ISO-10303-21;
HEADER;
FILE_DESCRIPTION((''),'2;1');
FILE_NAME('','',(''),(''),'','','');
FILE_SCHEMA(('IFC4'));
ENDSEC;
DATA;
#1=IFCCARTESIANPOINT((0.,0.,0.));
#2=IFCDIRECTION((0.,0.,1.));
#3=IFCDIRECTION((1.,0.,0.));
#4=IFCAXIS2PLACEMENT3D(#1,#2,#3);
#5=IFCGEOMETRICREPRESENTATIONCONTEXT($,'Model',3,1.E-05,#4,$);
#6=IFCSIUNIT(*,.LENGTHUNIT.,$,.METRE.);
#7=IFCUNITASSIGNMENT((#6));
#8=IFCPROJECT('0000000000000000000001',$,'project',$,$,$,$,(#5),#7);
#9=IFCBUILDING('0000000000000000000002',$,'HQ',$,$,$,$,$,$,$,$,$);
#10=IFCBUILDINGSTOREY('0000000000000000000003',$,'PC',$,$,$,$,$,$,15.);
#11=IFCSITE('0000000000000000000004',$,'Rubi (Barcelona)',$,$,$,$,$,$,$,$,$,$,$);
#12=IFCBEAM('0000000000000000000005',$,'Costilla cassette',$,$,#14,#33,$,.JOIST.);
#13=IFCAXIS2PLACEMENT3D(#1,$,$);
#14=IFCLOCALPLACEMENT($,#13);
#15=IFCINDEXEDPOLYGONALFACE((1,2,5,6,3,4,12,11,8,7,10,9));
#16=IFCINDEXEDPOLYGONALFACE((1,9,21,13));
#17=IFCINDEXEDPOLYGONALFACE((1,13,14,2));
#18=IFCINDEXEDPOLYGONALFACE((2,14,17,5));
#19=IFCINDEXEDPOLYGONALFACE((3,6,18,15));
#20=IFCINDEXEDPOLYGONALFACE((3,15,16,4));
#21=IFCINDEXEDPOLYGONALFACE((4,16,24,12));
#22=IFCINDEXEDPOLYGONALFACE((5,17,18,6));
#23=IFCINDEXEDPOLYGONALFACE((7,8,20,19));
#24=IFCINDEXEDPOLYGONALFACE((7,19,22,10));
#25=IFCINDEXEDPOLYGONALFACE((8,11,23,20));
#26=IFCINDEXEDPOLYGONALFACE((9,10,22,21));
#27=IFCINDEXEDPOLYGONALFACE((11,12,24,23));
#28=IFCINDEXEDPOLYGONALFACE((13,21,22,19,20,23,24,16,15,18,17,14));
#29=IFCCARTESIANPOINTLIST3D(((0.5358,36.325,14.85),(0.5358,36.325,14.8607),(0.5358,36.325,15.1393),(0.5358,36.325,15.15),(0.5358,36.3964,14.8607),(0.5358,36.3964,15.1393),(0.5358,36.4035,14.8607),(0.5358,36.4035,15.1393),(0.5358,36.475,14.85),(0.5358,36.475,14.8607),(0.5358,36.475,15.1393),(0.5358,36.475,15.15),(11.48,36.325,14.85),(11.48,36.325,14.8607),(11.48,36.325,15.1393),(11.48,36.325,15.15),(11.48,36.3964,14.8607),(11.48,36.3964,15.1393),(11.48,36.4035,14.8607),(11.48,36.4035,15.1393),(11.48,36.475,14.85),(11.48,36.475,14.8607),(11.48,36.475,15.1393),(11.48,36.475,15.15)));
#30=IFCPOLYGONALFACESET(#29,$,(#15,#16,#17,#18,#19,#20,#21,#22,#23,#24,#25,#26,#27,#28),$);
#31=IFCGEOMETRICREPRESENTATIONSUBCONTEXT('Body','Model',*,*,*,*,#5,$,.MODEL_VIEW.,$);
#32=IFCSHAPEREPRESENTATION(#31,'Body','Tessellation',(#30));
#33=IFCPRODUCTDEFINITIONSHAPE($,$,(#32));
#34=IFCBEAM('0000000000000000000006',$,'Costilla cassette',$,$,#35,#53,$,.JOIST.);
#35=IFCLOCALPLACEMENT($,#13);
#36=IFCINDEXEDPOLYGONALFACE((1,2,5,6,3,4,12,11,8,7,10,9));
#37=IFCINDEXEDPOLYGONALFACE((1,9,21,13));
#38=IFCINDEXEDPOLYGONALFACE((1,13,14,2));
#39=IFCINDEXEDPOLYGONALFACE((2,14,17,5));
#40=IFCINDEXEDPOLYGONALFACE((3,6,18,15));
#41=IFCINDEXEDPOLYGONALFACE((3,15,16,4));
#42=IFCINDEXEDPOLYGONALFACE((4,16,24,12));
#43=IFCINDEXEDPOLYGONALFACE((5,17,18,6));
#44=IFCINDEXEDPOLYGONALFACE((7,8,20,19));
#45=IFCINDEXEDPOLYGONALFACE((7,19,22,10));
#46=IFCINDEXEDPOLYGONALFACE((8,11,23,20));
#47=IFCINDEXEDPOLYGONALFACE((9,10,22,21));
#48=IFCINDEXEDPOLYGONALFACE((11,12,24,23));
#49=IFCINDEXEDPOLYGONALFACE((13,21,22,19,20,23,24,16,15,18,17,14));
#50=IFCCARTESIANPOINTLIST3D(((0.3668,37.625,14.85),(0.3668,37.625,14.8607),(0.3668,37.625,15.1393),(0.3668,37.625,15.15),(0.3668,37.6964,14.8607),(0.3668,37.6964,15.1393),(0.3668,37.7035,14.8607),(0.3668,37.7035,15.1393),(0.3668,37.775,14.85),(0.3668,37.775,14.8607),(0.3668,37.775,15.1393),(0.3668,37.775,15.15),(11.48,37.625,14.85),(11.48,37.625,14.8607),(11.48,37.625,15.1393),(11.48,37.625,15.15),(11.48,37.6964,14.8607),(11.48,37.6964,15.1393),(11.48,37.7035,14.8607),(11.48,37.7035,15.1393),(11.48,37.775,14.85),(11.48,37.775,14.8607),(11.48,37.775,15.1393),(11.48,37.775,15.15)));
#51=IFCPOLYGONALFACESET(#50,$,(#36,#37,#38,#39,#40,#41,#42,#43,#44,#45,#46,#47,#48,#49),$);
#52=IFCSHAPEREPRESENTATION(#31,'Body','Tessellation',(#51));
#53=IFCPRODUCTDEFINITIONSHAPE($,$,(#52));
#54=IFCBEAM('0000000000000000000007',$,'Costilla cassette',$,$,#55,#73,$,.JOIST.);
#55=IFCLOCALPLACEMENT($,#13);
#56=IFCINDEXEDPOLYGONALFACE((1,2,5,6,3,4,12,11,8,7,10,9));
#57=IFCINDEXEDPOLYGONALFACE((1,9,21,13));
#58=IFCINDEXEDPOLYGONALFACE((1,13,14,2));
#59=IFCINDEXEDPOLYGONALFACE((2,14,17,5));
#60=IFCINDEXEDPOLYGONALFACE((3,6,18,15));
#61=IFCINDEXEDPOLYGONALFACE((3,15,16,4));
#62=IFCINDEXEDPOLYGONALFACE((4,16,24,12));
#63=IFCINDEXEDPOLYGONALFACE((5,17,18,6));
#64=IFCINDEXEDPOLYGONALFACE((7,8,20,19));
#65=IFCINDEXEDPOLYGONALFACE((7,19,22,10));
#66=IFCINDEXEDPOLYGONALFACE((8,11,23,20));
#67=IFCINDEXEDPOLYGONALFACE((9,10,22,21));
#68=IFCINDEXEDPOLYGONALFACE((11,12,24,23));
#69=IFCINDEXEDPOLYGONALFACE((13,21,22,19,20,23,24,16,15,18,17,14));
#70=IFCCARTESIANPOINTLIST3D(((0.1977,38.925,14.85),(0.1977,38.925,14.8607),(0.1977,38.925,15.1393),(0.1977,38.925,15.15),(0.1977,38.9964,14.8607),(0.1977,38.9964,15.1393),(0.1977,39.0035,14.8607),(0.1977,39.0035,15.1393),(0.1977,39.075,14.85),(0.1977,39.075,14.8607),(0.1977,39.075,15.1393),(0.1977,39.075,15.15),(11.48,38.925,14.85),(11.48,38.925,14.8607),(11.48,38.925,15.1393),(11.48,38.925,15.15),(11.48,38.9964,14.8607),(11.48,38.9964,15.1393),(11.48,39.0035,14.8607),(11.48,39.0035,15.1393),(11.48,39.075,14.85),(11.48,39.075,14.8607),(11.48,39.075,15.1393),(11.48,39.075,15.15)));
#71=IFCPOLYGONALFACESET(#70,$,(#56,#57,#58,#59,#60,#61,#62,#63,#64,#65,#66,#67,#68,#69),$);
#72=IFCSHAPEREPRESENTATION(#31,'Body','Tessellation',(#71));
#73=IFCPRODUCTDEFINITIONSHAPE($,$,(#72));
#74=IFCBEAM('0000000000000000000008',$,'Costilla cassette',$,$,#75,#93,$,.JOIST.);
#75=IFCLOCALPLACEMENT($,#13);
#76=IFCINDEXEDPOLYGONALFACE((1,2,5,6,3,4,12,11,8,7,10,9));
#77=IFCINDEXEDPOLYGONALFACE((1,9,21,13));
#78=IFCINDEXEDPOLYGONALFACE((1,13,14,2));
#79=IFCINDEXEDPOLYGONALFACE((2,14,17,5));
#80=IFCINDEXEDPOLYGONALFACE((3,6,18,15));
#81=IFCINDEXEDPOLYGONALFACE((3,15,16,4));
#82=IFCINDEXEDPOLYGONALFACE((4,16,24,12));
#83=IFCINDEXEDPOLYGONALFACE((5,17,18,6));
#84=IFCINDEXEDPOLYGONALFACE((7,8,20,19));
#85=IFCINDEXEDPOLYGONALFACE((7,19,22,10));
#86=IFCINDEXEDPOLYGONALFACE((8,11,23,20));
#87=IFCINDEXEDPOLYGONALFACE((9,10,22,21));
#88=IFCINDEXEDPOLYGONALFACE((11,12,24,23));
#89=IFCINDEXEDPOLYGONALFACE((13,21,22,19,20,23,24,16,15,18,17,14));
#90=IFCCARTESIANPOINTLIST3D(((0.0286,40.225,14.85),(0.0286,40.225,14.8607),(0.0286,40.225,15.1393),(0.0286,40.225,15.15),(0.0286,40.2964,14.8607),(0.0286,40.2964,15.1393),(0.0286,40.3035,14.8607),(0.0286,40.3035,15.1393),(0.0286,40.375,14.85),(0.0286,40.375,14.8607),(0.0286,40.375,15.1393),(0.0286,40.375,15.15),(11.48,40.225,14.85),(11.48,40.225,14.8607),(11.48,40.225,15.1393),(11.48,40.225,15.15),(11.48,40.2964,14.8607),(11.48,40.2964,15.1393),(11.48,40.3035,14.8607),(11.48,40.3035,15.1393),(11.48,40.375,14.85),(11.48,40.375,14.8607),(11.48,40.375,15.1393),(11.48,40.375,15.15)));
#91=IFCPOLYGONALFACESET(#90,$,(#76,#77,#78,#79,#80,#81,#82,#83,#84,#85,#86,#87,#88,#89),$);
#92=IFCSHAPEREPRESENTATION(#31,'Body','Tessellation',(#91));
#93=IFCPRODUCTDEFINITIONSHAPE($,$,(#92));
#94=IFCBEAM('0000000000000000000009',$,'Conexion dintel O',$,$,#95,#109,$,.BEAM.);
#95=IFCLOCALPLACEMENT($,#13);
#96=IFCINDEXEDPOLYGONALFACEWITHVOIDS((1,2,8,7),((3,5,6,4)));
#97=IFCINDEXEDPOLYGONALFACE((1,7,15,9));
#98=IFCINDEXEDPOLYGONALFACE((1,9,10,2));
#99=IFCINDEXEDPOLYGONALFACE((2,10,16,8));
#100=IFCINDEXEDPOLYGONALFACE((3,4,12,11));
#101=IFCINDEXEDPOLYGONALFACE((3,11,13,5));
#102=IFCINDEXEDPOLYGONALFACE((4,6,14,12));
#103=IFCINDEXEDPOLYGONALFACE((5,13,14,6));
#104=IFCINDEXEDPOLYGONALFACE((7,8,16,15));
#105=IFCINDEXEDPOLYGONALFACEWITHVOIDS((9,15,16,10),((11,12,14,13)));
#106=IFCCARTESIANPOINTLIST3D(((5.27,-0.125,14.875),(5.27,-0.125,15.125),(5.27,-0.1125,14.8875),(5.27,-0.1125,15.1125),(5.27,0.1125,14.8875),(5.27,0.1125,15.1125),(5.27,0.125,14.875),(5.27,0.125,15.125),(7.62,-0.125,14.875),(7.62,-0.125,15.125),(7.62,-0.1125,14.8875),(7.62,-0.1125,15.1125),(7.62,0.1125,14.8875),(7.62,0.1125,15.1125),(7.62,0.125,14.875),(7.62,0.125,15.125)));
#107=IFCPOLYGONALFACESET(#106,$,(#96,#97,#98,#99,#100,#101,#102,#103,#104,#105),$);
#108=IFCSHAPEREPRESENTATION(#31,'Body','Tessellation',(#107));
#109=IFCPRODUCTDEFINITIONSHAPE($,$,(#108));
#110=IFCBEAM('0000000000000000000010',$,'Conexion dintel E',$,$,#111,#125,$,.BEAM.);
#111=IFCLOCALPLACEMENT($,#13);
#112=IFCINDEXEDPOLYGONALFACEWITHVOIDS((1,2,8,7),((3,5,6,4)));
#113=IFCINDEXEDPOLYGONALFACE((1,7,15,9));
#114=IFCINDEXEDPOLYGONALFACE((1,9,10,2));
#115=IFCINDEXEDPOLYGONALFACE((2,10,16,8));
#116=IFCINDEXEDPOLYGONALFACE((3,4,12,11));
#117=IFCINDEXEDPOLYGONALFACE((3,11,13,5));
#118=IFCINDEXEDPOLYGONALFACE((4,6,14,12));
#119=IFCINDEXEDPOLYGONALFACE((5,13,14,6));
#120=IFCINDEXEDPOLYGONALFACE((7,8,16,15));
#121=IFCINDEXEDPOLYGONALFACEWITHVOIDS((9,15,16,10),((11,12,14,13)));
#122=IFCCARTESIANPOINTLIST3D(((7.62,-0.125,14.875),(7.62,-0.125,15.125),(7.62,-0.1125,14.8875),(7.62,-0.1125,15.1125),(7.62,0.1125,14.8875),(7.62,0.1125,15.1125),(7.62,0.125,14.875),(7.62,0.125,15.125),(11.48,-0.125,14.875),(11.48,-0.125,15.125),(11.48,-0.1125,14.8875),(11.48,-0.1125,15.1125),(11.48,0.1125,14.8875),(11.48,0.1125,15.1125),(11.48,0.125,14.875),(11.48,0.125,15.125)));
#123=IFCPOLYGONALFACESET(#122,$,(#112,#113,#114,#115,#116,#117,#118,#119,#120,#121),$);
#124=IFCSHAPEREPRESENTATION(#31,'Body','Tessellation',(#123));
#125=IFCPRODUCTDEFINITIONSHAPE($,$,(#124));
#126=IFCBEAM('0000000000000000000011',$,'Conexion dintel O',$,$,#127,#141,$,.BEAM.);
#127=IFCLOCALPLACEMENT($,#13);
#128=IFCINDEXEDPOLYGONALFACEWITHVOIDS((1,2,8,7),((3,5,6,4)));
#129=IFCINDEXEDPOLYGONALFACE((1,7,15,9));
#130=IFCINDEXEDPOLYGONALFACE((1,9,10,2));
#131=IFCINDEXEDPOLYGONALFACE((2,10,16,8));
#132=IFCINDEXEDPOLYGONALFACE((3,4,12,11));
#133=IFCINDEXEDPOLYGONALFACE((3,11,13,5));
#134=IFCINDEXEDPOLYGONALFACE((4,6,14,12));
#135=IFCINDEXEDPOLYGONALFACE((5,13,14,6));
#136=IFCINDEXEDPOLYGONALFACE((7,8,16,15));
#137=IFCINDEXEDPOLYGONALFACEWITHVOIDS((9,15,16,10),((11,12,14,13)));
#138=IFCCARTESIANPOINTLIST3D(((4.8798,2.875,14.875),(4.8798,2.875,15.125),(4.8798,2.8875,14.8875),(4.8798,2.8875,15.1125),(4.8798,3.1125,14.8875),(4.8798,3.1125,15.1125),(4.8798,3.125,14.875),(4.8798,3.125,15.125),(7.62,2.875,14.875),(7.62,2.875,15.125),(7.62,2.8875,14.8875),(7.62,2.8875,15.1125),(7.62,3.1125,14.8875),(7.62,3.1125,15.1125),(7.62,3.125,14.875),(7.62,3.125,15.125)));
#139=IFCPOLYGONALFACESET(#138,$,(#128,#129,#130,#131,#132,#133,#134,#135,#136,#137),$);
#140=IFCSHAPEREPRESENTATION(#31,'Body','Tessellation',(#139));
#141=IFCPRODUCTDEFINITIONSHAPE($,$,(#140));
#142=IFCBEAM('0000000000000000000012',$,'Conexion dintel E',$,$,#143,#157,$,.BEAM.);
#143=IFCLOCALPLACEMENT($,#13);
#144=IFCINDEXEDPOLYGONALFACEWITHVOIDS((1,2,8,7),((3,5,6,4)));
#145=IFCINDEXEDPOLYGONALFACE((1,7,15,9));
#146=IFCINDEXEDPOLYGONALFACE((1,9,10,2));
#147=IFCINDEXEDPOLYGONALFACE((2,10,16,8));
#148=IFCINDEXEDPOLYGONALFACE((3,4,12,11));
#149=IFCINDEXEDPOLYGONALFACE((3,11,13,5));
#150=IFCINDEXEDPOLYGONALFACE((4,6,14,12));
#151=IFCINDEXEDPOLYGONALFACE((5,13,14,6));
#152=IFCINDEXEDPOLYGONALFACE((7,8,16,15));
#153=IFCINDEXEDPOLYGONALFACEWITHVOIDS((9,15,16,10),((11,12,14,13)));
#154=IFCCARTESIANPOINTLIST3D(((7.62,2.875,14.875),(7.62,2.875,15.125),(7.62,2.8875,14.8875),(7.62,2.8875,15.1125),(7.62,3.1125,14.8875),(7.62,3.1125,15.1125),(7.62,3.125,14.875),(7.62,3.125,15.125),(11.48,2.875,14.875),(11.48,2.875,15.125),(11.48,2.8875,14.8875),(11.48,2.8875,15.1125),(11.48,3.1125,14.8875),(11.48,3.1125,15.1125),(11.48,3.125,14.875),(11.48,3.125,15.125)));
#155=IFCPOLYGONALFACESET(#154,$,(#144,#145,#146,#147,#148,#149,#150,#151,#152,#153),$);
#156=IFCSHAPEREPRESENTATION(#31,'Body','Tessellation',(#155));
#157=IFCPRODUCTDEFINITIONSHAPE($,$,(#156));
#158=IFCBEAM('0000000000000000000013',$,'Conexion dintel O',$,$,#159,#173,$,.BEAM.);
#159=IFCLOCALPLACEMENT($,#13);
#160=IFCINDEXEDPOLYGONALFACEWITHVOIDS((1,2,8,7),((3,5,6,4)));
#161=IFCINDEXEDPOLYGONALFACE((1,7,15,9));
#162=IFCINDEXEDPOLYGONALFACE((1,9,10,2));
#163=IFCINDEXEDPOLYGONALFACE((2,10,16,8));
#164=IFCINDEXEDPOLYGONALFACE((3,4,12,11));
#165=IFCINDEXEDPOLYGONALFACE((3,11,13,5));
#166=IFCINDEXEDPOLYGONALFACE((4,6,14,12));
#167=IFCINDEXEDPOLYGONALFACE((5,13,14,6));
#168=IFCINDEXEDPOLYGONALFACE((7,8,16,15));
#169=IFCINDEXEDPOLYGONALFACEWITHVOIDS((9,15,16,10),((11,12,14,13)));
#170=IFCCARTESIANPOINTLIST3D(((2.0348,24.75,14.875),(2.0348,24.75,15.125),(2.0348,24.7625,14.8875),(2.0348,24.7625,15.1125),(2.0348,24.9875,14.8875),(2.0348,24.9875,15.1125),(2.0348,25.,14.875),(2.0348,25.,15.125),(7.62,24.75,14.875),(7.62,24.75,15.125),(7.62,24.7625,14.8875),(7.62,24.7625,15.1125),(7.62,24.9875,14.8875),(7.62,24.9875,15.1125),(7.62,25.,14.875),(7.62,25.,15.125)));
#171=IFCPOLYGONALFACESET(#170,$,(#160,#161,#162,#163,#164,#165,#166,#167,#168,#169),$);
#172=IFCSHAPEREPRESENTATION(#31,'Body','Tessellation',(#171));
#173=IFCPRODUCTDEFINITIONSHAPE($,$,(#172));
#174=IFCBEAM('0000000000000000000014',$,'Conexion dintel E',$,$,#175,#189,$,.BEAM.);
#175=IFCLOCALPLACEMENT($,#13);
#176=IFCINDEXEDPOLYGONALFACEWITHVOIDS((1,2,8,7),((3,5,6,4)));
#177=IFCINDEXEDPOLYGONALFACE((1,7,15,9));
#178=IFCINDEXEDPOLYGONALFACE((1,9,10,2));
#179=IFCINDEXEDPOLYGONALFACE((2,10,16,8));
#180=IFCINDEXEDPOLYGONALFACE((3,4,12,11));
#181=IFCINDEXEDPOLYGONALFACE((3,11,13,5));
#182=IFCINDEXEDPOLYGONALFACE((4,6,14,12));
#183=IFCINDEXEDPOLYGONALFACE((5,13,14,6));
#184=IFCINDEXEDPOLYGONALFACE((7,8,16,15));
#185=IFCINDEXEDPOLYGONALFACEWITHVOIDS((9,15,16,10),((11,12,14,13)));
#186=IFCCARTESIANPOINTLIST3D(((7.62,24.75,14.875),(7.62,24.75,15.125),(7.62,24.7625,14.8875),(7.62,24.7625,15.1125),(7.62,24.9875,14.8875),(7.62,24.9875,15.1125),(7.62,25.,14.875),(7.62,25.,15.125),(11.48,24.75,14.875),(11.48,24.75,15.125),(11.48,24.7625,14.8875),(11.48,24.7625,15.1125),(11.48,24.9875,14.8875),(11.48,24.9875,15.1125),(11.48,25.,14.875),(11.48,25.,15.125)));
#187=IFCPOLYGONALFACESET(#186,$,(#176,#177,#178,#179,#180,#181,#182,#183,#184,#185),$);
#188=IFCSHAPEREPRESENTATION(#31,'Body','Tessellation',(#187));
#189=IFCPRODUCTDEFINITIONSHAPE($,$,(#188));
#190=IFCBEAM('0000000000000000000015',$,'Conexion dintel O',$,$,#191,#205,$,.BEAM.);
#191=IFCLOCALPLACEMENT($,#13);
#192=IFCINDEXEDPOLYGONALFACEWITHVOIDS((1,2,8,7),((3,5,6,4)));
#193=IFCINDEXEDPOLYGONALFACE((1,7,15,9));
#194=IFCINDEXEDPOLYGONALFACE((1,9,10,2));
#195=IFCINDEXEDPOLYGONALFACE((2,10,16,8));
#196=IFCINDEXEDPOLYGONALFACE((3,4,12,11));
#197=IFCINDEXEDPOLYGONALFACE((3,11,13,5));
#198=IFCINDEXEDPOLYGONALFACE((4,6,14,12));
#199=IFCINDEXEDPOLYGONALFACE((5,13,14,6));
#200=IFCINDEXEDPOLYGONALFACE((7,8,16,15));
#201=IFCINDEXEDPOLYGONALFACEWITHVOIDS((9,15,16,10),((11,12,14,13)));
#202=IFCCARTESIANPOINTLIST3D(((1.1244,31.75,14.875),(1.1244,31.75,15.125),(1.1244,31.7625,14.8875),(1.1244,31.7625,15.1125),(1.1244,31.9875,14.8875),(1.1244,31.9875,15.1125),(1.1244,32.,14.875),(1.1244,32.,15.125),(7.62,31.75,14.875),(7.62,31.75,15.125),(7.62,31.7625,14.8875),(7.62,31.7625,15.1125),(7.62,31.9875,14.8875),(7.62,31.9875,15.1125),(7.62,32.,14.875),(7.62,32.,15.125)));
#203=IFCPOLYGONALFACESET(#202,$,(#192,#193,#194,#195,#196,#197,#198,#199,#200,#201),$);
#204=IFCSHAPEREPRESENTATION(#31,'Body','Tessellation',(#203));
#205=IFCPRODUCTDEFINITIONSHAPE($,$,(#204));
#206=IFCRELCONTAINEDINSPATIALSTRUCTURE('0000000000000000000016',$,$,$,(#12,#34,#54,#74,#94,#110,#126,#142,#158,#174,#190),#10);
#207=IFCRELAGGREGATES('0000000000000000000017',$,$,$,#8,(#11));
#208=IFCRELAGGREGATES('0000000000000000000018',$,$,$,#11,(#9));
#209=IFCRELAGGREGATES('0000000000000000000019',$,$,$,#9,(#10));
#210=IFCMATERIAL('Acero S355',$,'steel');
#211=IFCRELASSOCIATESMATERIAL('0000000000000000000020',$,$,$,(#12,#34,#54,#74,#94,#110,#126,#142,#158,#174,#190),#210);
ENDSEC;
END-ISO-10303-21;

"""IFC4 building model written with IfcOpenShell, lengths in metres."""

from ifc_helpers import new_model, si_unit, frame, origin_with_axes, place, context, subcontext, project, spatial, hollow_rectangle, i_section, extrude, material, element, save


model = new_model("IFC4")

# Units and contexts
model_context = context("Model", 3, precision=1e-05, world=origin_with_axes())
body_context = subcontext(model_context, "Body", "Model", "MODEL_VIEW")
ifc_project = project(units=[si_unit("LENGTHUNIT", "METRE")], contexts=[model_context])

# Site, building, storey
site = spatial("IfcSite", under=ifc_project, Name="Rubi (Barcelona)")
building = spatial("IfcBuilding", under=site, Name="HQ")
storey = spatial("IfcBuildingStorey", under=building, Name="PC", Elevation=15.0)

# Beams
ifc_material_1 = material(Name="Acero S355", Category="steel")
beam_1_placement = place(None, origin_with_axes())
element("IfcBeam", 1, at=beam_1_placement, inside=storey, material=ifc_material_1, Name="Costilla cassette", PredefinedType="JOIST", context=body_context, shape_type="SweptSolid", body=[
    extrude(i_section(OverallWidth=0.15, OverallDepth=0.3, WebThickness=0.0071, FlangeThickness=0.0107), frame((0.5358, 36.4, 15.0), z_axis=(1.0, 0.0, 0.0), x_axis=(0.0, 1.0, 0.0)), (0.0, 0.0, 1.0), 10.9442),
])
beam_2_placement = place(None, origin_with_axes())
element("IfcBeam", 2, at=beam_2_placement, inside=storey, material=ifc_material_1, Name="Costilla cassette", PredefinedType="JOIST", context=body_context, shape_type="SweptSolid", body=[
    extrude(i_section(OverallWidth=0.15, OverallDepth=0.3, WebThickness=0.0071, FlangeThickness=0.0107), frame((0.3668, 37.7, 15.0), z_axis=(1.0, 0.0, 0.0), x_axis=(0.0, 1.0, 0.0)), (0.0, 0.0, 1.0), 11.1132),
])
beam_3_placement = place(None, origin_with_axes())
element("IfcBeam", 3, at=beam_3_placement, inside=storey, material=ifc_material_1, Name="Costilla cassette", PredefinedType="JOIST", context=body_context, shape_type="SweptSolid", body=[
    extrude(i_section(OverallWidth=0.15, OverallDepth=0.3, WebThickness=0.0071, FlangeThickness=0.0107), frame((0.1977, 39.0, 15.0), z_axis=(1.0, 0.0, 0.0), x_axis=(0.0, 1.0, 0.0)), (0.0, 0.0, 1.0), 11.2823),
])
beam_4_placement = place(None, origin_with_axes())
element("IfcBeam", 4, at=beam_4_placement, inside=storey, material=ifc_material_1, Name="Costilla cassette", PredefinedType="JOIST", context=body_context, shape_type="SweptSolid", body=[
    extrude(i_section(OverallWidth=0.15, OverallDepth=0.3, WebThickness=0.0071, FlangeThickness=0.0107), frame((0.0286, 40.3, 15.0), z_axis=(1.0, 0.0, 0.0), x_axis=(0.0, 1.0, 0.0)), (0.0, 0.0, 1.0), 11.4514),
])
beam_5_placement = place(None, origin_with_axes())
element("IfcBeam", 5, at=beam_5_placement, inside=storey, material=ifc_material_1, Name="Conexion dintel O", PredefinedType="BEAM", context=body_context, shape_type="SweptSolid", body=[
    extrude(hollow_rectangle(XDim=0.25, YDim=0.25, WallThickness=0.0125), frame((5.27, 0.0, 15.0), z_axis=(1.0, 0.0, 0.0), x_axis=(0.0, 1.0, 0.0)), (0.0, 0.0, 1.0), 2.35),
])
beam_6_placement = place(None, origin_with_axes())
element("IfcBeam", 6, at=beam_6_placement, inside=storey, material=ifc_material_1, Name="Conexion dintel E", PredefinedType="BEAM", context=body_context, shape_type="SweptSolid", body=[
    extrude(hollow_rectangle(XDim=0.25, YDim=0.25, WallThickness=0.0125), frame((7.62, 0.0, 15.0), z_axis=(1.0, 0.0, 0.0), x_axis=(0.0, 1.0, 0.0)), (0.0, 0.0, 1.0), 3.86),
])
beam_7_placement = place(None, origin_with_axes())
element("IfcBeam", 7, at=beam_7_placement, inside=storey, material=ifc_material_1, Name="Conexion dintel O", PredefinedType="BEAM", context=body_context, shape_type="SweptSolid", body=[
    extrude(hollow_rectangle(XDim=0.25, YDim=0.25, WallThickness=0.0125), frame((4.8798, 3.0, 15.0), z_axis=(1.0, 0.0, 0.0), x_axis=(0.0, 1.0, 0.0)), (0.0, 0.0, 1.0), 2.7402),
])
beam_8_placement = place(None, origin_with_axes())
element("IfcBeam", 8, at=beam_8_placement, inside=storey, material=ifc_material_1, Name="Conexion dintel E", PredefinedType="BEAM", context=body_context, shape_type="SweptSolid", body=[
    extrude(hollow_rectangle(XDim=0.25, YDim=0.25, WallThickness=0.0125), frame((7.62, 3.0, 15.0), z_axis=(1.0, 0.0, 0.0), x_axis=(0.0, 1.0, 0.0)), (0.0, 0.0, 1.0), 3.86),
])
beam_9_placement = place(None, origin_with_axes())
element("IfcBeam", 9, at=beam_9_placement, inside=storey, material=ifc_material_1, Name="Conexion dintel O", PredefinedType="BEAM", context=body_context, shape_type="SweptSolid", body=[
    extrude(hollow_rectangle(XDim=0.25, YDim=0.25, WallThickness=0.0125), frame((2.0348, 24.875, 15.0), z_axis=(1.0, 0.0, 0.0), x_axis=(0.0, 1.0, 0.0)), (0.0, 0.0, 1.0), 5.5852),
])
beam_10_placement = place(None, origin_with_axes())
element("IfcBeam", 10, at=beam_10_placement, inside=storey, material=ifc_material_1, Name="Conexion dintel E", PredefinedType="BEAM", context=body_context, shape_type="SweptSolid", body=[
    extrude(hollow_rectangle(XDim=0.25, YDim=0.25, WallThickness=0.0125), frame((7.62, 24.875, 15.0), z_axis=(1.0, 0.0, 0.0), x_axis=(0.0, 1.0, 0.0)), (0.0, 0.0, 1.0), 3.86),
])
beam_11_placement = place(None, origin_with_axes())
element("IfcBeam", 11, at=beam_11_placement, inside=storey, material=ifc_material_1, Name="Conexion dintel O", PredefinedType="BEAM", context=body_context, shape_type="SweptSolid", body=[
    extrude(hollow_rectangle(XDim=0.25, YDim=0.25, WallThickness=0.0125), frame((1.1244, 31.875, 15.0), z_axis=(1.0, 0.0, 0.0), x_axis=(0.0, 1.0, 0.0)), (0.0, 0.0, 1.0), 6.4956),
])

save(model, "model.ifc")
